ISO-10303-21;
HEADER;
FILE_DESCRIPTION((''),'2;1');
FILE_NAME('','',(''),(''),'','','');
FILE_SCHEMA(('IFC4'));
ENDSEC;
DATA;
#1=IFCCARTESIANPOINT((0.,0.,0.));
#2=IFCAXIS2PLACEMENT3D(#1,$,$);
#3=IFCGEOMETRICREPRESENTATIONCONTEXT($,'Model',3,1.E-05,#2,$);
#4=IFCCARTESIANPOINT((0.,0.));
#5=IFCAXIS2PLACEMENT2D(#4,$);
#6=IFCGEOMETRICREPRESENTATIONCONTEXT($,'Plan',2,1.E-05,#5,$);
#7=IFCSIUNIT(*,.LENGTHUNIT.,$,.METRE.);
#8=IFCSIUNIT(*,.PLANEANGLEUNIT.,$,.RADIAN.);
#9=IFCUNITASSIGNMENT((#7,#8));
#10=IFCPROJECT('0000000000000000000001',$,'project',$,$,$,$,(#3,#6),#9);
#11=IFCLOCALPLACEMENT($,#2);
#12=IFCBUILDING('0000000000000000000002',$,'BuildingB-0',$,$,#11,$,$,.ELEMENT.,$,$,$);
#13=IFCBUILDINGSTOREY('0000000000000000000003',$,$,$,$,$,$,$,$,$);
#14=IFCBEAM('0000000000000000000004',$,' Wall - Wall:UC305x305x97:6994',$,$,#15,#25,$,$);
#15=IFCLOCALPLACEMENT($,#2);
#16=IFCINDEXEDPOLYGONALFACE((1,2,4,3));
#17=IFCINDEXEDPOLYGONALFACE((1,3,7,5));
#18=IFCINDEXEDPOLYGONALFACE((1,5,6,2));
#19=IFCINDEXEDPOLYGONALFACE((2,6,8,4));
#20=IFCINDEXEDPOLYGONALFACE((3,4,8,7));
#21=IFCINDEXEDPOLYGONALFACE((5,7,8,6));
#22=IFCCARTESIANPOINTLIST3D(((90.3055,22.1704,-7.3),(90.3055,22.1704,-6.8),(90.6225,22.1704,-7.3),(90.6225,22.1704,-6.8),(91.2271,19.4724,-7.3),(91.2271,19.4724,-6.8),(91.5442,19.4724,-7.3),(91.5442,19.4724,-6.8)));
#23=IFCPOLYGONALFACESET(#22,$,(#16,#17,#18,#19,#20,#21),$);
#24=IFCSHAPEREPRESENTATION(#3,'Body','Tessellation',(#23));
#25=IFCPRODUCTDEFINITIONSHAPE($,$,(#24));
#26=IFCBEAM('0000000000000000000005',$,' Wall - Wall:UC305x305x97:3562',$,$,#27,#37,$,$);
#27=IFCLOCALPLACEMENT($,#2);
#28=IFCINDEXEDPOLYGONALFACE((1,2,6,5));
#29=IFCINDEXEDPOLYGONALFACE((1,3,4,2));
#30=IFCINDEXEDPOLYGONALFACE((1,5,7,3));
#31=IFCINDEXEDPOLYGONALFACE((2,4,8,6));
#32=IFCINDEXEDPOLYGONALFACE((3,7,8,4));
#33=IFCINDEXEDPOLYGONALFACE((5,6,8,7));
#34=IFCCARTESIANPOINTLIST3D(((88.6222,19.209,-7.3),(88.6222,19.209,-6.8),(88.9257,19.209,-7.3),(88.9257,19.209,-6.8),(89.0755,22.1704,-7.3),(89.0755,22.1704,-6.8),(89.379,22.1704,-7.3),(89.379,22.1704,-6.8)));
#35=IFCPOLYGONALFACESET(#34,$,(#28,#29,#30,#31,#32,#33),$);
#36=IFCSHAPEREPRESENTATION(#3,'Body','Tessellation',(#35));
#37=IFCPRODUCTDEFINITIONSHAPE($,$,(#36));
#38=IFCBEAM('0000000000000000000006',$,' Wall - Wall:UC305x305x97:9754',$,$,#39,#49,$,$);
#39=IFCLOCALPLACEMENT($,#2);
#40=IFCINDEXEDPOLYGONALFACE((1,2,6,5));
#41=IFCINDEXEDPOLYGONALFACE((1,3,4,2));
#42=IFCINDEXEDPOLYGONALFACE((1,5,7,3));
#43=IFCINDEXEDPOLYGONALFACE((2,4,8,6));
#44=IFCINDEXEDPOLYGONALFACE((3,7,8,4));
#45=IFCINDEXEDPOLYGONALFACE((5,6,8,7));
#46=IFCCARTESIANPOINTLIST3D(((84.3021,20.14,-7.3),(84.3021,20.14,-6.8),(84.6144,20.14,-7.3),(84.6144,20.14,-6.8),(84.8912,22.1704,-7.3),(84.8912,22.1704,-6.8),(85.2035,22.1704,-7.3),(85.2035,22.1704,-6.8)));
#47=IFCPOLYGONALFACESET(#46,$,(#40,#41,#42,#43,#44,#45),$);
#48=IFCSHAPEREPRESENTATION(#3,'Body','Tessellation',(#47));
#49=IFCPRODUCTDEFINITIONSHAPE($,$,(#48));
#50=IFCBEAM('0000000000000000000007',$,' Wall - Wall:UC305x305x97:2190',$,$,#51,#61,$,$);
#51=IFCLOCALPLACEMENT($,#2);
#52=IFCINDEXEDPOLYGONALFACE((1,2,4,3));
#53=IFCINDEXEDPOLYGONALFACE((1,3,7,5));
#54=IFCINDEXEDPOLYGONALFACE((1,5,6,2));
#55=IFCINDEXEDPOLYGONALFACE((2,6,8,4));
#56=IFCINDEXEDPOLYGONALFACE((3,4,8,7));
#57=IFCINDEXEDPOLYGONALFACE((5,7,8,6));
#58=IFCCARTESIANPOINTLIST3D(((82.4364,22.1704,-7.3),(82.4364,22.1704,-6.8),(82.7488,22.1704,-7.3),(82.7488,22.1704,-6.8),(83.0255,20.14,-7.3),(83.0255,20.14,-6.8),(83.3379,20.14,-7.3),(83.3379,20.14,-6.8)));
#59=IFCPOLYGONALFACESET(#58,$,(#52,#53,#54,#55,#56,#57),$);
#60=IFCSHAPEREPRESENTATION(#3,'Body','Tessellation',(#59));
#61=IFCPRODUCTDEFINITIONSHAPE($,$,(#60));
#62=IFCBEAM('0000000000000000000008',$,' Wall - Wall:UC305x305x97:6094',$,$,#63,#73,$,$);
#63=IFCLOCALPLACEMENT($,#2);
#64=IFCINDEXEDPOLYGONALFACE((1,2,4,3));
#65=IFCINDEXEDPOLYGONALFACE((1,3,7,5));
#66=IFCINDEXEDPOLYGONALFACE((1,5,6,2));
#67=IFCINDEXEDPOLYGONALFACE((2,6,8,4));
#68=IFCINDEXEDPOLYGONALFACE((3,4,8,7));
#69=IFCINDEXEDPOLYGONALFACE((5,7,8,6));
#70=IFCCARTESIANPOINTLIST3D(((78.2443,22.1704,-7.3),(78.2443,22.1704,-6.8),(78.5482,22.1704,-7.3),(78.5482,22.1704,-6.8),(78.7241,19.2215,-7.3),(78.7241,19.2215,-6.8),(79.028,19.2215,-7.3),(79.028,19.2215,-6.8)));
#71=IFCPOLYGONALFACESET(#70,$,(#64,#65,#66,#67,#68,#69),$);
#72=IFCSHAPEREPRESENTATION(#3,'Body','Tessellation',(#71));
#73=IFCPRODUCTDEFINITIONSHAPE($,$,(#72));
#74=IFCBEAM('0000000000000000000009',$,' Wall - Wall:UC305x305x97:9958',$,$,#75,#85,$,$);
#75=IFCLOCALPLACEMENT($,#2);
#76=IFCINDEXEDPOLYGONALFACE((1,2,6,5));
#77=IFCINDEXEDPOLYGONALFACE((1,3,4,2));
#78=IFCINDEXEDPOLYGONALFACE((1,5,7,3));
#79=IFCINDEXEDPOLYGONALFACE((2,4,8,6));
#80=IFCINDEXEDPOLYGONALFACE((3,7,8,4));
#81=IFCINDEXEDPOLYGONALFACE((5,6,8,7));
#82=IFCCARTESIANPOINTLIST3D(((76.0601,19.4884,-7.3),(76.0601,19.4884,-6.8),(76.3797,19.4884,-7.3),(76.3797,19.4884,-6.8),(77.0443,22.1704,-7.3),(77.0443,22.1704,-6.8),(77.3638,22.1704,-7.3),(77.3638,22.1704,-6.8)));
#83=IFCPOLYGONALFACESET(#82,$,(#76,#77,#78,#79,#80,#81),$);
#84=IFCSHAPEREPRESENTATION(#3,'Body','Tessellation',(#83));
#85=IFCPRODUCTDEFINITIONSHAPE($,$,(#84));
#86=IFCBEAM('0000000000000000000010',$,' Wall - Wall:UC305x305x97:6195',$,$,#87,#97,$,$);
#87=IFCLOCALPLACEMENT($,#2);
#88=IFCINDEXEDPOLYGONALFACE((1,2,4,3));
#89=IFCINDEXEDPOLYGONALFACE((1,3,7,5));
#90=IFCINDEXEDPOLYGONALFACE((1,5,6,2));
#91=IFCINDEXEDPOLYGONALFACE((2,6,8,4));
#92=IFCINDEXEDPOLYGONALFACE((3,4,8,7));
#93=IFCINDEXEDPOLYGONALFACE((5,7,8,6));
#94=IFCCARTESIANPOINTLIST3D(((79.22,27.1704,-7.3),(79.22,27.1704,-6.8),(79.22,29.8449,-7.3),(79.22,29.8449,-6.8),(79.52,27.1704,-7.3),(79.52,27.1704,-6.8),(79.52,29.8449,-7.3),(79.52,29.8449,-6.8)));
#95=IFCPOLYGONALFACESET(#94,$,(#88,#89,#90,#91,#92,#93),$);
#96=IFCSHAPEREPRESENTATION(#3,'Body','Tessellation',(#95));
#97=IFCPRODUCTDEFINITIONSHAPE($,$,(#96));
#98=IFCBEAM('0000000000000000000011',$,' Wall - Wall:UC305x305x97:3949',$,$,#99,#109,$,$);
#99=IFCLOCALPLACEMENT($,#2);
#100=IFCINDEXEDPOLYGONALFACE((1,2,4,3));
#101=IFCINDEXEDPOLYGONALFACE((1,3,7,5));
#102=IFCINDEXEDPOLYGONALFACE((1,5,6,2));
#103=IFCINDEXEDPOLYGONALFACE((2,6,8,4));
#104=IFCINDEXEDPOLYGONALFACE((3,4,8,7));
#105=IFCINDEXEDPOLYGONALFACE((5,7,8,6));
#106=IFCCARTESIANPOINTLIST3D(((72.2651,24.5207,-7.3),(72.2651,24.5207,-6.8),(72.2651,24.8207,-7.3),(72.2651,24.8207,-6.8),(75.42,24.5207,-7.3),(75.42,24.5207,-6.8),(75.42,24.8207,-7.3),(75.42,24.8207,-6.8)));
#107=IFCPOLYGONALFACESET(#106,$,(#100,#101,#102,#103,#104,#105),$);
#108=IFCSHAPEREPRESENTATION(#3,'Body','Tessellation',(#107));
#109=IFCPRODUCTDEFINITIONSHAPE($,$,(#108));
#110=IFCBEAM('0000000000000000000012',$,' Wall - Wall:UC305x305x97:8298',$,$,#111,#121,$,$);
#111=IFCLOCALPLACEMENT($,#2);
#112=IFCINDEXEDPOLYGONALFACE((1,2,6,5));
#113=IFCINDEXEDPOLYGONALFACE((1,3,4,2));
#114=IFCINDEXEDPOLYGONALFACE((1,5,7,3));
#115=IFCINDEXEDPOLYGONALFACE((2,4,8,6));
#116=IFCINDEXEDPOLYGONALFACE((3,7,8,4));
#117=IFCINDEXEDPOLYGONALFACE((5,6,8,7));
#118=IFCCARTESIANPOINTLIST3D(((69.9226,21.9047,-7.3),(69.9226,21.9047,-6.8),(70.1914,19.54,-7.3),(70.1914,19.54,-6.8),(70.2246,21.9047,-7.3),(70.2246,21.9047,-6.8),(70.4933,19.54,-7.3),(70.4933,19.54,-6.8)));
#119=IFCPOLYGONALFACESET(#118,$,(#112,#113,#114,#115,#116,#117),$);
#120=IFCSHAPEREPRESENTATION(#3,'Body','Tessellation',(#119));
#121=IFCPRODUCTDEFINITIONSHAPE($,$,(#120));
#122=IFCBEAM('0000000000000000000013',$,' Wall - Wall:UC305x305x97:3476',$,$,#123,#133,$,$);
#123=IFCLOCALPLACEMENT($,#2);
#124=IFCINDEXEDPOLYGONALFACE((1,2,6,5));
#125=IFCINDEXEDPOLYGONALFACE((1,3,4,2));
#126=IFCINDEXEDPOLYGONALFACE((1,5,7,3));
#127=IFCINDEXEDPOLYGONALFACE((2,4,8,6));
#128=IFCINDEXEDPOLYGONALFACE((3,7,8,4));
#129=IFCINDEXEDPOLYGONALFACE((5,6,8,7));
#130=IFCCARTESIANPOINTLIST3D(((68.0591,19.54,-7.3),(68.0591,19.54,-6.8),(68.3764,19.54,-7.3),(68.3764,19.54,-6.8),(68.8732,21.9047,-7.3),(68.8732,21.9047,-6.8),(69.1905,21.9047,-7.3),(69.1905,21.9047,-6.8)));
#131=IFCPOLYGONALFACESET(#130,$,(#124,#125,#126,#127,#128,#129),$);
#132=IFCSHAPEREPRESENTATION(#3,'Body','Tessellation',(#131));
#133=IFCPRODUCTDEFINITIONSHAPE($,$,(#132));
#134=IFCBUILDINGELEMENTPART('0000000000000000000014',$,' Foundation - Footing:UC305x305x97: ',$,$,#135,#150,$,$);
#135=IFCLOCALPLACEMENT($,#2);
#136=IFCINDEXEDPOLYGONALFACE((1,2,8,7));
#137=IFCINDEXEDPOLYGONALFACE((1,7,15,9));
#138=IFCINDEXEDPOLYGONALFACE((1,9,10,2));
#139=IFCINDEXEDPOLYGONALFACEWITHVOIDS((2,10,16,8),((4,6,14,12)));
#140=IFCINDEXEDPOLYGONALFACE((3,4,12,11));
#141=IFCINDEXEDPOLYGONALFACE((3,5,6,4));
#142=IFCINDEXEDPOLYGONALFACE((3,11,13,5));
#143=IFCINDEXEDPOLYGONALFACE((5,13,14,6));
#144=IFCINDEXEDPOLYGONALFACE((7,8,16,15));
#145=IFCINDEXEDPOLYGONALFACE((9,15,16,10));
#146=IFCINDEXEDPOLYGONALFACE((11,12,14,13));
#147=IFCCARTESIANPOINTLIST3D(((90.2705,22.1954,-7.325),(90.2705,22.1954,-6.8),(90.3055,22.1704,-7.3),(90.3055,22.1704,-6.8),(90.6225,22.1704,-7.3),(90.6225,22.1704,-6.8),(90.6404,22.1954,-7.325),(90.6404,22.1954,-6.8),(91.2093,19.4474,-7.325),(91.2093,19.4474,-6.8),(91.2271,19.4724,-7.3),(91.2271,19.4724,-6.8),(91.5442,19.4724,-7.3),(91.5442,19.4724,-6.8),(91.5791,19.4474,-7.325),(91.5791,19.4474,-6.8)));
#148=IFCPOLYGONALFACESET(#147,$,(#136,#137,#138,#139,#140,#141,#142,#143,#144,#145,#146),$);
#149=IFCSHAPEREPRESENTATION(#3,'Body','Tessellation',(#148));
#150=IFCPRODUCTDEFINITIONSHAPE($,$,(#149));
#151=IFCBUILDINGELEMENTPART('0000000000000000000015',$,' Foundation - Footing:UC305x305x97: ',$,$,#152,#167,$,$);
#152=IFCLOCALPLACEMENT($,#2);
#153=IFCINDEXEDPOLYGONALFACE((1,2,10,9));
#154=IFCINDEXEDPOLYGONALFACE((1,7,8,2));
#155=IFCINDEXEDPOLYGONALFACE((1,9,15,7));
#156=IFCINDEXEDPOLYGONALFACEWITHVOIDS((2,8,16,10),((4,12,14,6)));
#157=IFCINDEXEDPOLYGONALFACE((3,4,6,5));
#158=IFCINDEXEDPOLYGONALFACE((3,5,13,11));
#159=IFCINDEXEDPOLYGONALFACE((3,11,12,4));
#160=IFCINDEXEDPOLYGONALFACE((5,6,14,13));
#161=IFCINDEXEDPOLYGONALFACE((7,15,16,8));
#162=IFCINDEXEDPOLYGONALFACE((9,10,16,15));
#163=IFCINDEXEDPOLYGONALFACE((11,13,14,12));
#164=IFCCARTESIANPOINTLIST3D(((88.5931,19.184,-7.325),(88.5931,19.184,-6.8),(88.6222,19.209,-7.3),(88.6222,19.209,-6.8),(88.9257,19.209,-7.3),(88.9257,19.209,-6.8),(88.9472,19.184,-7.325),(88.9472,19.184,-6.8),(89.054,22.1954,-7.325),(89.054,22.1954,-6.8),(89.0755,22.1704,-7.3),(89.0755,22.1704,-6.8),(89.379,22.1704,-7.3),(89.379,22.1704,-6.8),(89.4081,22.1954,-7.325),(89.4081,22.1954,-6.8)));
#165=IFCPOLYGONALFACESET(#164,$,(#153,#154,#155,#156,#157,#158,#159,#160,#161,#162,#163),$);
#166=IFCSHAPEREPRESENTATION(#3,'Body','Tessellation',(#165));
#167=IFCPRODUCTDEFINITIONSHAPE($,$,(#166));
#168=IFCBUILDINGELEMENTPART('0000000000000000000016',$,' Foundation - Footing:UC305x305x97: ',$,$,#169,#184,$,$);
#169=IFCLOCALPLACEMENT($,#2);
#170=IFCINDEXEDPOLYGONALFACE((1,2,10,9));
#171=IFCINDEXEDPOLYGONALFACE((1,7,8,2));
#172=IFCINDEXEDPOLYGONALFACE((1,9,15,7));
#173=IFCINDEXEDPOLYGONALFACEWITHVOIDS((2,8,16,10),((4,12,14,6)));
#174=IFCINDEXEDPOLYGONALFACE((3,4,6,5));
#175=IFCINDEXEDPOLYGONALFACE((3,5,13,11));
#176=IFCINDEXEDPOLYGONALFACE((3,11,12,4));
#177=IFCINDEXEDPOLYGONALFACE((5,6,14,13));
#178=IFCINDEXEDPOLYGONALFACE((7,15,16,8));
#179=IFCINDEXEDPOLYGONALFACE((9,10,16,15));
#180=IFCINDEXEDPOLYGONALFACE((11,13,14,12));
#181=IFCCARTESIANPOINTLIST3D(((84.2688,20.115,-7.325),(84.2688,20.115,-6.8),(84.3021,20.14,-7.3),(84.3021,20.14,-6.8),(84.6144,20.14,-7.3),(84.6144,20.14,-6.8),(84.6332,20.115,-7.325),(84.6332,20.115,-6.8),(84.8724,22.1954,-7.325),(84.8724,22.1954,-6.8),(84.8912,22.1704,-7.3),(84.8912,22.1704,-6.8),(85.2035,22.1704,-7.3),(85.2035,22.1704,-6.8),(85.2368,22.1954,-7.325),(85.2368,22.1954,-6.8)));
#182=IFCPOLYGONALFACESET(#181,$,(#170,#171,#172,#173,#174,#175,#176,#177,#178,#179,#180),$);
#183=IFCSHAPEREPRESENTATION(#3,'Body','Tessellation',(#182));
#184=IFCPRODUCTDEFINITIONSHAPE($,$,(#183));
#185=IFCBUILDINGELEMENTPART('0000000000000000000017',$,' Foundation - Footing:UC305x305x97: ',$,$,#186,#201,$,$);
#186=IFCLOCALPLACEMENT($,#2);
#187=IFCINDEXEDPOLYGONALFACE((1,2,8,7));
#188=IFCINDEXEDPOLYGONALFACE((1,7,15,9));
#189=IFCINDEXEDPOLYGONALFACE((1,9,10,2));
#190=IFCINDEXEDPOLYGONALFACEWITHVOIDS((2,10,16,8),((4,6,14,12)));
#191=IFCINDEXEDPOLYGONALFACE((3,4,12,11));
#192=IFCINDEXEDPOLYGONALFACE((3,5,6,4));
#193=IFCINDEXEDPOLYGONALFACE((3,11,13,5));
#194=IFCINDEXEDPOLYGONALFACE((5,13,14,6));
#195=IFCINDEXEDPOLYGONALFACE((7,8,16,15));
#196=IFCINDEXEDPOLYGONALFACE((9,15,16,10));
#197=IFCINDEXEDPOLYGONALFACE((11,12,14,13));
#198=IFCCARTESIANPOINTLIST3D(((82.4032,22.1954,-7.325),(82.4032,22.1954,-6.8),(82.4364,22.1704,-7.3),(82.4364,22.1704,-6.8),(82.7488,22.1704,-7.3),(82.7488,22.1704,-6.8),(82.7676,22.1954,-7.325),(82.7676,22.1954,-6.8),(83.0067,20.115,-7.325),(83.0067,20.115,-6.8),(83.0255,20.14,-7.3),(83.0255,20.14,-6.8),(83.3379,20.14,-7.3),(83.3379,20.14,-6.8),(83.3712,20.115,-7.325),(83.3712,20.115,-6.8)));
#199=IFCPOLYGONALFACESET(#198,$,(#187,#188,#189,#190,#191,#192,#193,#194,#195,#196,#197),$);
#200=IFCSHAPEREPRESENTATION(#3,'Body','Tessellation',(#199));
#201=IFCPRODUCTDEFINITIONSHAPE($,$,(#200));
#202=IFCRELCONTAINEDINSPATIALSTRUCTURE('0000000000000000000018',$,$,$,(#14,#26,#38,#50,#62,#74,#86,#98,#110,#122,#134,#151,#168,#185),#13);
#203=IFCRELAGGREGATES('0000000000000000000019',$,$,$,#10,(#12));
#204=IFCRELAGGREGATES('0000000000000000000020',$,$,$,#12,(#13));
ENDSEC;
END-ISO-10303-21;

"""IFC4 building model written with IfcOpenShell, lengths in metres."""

from ifc_helpers import new_model, si_unit, origin, origin_2d, place, context, project, spatial, polyline, outline, extrude, element, save


model = new_model("IFC4")

# Units and contexts
model_context = context("Model", 3, precision=1e-05, world=origin())
plan_context = context("Plan", 2, precision=1e-05, world=origin_2d())
ifc_project = project(units=[si_unit("LENGTHUNIT", "METRE"), si_unit("PLANEANGLEUNIT", "RADIAN")], contexts=[model_context, plan_context])

# Building, storey
building_placement = place(None, origin())
building = spatial("IfcBuilding", under=ifc_project, at=building_placement, Name="BuildingB-0", CompositionType="ELEMENT")
storey = spatial("IfcBuildingStorey", under=building)

# Beams
element("IfcBeam", 1, inside=storey, Name=" Wall - Wall:UC305x305x97:6994", context=model_context, shape_type="SweptSolid", body=[
    extrude(outline(polyline([(91.5442, 19.4724, -7.3), (91.2271, 19.4724, -7.3), (90.3055, 22.1704, -7.3), (90.6225, 22.1704, -7.3), (91.5442, 19.4724, -7.3)])), None, (0.0, 0.0, 1.0), 0.5),
])
element("IfcBeam", 2, inside=storey, Name=" Wall - Wall:UC305x305x97:3562", context=model_context, shape_type="SweptSolid", body=[
    extrude(outline(polyline([(88.9257, 19.209, -7.3), (88.6222, 19.209, -7.3), (89.0755, 22.1704, -7.3), (89.379, 22.1704, -7.3), (88.9257, 19.209, -7.3)])), None, (0.0, 0.0, 1.0), 0.5),
])
element("IfcBeam", 3, inside=storey, Name=" Wall - Wall:UC305x305x97:9754", context=model_context, shape_type="SweptSolid", body=[
    extrude(outline(polyline([(84.6144, 20.14, -7.3), (84.3021, 20.14, -7.3), (84.8912, 22.1704, -7.3), (85.2035, 22.1704, -7.3), (84.6144, 20.14, -7.3)])), None, (0.0, 0.0, 1.0), 0.5),
])
element("IfcBeam", 4, inside=storey, Name=" Wall - Wall:UC305x305x97:2190", context=model_context, shape_type="SweptSolid", body=[
    extrude(outline(polyline([(83.3379, 20.14, -7.3), (82.7488, 22.1704, -7.3), (82.4364, 22.1704, -7.3), (83.0255, 20.14, -7.3), (83.3379, 20.14, -7.3)])), None, (0.0, 0.0, 1.0), 0.5),
])
element("IfcBeam", 5, inside=storey, Name=" Wall - Wall:UC305x305x97:6094", context=model_context, shape_type="SweptSolid", body=[
    extrude(outline(polyline([(79.028, 19.2215, -7.3), (78.7241, 19.2215, -7.3), (78.2443, 22.1704, -7.3), (78.5482, 22.1704, -7.3), (79.028, 19.2215, -7.3)])), None, (0.0, 0.0, 1.0), 0.5),
])
element("IfcBeam", 6, inside=storey, Name=" Wall - Wall:UC305x305x97:9958", context=model_context, shape_type="SweptSolid", body=[
    extrude(outline(polyline([(76.3797, 19.4884, -7.3), (76.0601, 19.4884, -7.3), (77.0443, 22.1704, -7.3), (77.3638, 22.1704, -7.3), (76.3797, 19.4884, -7.3)])), None, (0.0, 0.0, 1.0), 0.5),
])
element("IfcBeam", 7, inside=storey, Name=" Wall - Wall:UC305x305x97:6195", context=model_context, shape_type="SweptSolid", body=[
    extrude(outline(polyline([(79.52, 27.1704, -7.3), (79.22, 27.1704, -7.3), (79.22, 29.8449, -7.3), (79.52, 29.8449, -7.3), (79.52, 27.1704, -7.3)])), None, (0.0, 0.0, 1.0), 0.5),
])
element("IfcBeam", 8, inside=storey, Name=" Wall - Wall:UC305x305x97:3949", context=model_context, shape_type="SweptSolid", body=[
    extrude(outline(polyline([(75.42, 24.5207, -7.3), (75.42, 24.8207, -7.3), (72.2651, 24.8207, -7.3), (72.2651, 24.5207, -7.3), (75.42, 24.5207, -7.3)])), None, (0.0, 0.0, 1.0), 0.5),
])
element("IfcBeam", 9, inside=storey, Name=" Wall - Wall:UC305x305x97:8298", context=model_context, shape_type="SweptSolid", body=[
    extrude(outline(polyline([(70.4933, 19.54, -7.3), (70.1914, 19.54, -7.3), (69.9226, 21.9047, -7.3), (70.2246, 21.9047, -7.3), (70.4933, 19.54, -7.3)])), None, (0.0, 0.0, 1.0), 0.5),
])
element("IfcBeam", 10, inside=storey, Name=" Wall - Wall:UC305x305x97:3476", context=model_context, shape_type="SweptSolid", body=[
    extrude(outline(polyline([(68.3764, 19.54, -7.3), (68.0591, 19.54, -7.3), (68.8732, 21.9047, -7.3), (69.1905, 21.9047, -7.3), (68.3764, 19.54, -7.3)])), None, (0.0, 0.0, 1.0), 0.5),
])

# Building element parts, openings
building_element_part_1 = element("IfcBuildingElementPart", 11, inside=storey, Name=" Foundation - Footing:UC305x305x97: ", context=model_context, shape_type="SweptSolid", body=[
    extrude(outline(polyline([(91.5791, 19.4474, -7.325), (91.2093, 19.4474, -7.325), (90.2705, 22.1954, -7.325), (90.6404, 22.1954, -7.325), (91.5791, 19.4474, -7.325)])), None, (0.0, 0.0, 1.0), 0.525),
])
element("IfcOpeningElement", 12, inside=storey, cuts=building_element_part_1, context=model_context, shape_type="SweptSolid", body=[
    extrude(outline(polyline([(91.5442, 19.4724, -7.3), (91.2271, 19.4724, -7.3), (90.3055, 22.1704, -7.3), (90.6225, 22.1704, -7.3), (91.5442, 19.4724, -7.3)])), None, (0.0, 0.0, 1.0), 0.5),
])
building_element_part_2 = element("IfcBuildingElementPart", 13, inside=storey, Name=" Foundation - Footing:UC305x305x97: ", context=model_context, shape_type="SweptSolid", body=[
    extrude(outline(polyline([(88.9472, 19.184, -7.325), (88.5931, 19.184, -7.325), (89.054, 22.1954, -7.325), (89.4081, 22.1954, -7.325), (88.9472, 19.184, -7.325)])), None, (0.0, 0.0, 1.0), 0.525),
])
element("IfcOpeningElement", 14, inside=storey, cuts=building_element_part_2, context=model_context, shape_type="SweptSolid", body=[
    extrude(outline(polyline([(88.9257, 19.209, -7.3), (88.6222, 19.209, -7.3), (89.0755, 22.1704, -7.3), (89.379, 22.1704, -7.3), (88.9257, 19.209, -7.3)])), None, (0.0, 0.0, 1.0), 0.5),
])
building_element_part_3 = element("IfcBuildingElementPart", 15, inside=storey, Name=" Foundation - Footing:UC305x305x97: ", context=model_context, shape_type="SweptSolid", body=[
    extrude(outline(polyline([(84.6332, 20.115, -7.325), (84.2688, 20.115, -7.325), (84.8724, 22.1954, -7.325), (85.2368, 22.1954, -7.325), (84.6332, 20.115, -7.325)])), None, (0.0, 0.0, 1.0), 0.525),
])
element("IfcOpeningElement", 16, inside=storey, cuts=building_element_part_3, context=model_context, shape_type="SweptSolid", body=[
    extrude(outline(polyline([(84.6144, 20.14, -7.3), (84.3021, 20.14, -7.3), (84.8912, 22.1704, -7.3), (85.2035, 22.1704, -7.3), (84.6144, 20.14, -7.3)])), None, (0.0, 0.0, 1.0), 0.5),
])
building_element_part_4 = element("IfcBuildingElementPart", 17, inside=storey, Name=" Foundation - Footing:UC305x305x97: ", context=model_context, shape_type="SweptSolid", body=[
    extrude(outline(polyline([(83.3712, 20.115, -7.325), (82.7676, 22.1954, -7.325), (82.4032, 22.1954, -7.325), (83.0067, 20.115, -7.325), (83.3712, 20.115, -7.325)])), None, (0.0, 0.0, 1.0), 0.525),
])
element("IfcOpeningElement", 18, inside=storey, cuts=building_element_part_4, context=model_context, shape_type="SweptSolid", body=[
    extrude(outline(polyline([(83.3379, 20.14, -7.3), (82.7488, 22.1704, -7.3), (82.4364, 22.1704, -7.3), (83.0255, 20.14, -7.3), (83.3379, 20.14, -7.3)])), None, (0.0, 0.0, 1.0), 0.5),
])

save(model, "model.ifc")
